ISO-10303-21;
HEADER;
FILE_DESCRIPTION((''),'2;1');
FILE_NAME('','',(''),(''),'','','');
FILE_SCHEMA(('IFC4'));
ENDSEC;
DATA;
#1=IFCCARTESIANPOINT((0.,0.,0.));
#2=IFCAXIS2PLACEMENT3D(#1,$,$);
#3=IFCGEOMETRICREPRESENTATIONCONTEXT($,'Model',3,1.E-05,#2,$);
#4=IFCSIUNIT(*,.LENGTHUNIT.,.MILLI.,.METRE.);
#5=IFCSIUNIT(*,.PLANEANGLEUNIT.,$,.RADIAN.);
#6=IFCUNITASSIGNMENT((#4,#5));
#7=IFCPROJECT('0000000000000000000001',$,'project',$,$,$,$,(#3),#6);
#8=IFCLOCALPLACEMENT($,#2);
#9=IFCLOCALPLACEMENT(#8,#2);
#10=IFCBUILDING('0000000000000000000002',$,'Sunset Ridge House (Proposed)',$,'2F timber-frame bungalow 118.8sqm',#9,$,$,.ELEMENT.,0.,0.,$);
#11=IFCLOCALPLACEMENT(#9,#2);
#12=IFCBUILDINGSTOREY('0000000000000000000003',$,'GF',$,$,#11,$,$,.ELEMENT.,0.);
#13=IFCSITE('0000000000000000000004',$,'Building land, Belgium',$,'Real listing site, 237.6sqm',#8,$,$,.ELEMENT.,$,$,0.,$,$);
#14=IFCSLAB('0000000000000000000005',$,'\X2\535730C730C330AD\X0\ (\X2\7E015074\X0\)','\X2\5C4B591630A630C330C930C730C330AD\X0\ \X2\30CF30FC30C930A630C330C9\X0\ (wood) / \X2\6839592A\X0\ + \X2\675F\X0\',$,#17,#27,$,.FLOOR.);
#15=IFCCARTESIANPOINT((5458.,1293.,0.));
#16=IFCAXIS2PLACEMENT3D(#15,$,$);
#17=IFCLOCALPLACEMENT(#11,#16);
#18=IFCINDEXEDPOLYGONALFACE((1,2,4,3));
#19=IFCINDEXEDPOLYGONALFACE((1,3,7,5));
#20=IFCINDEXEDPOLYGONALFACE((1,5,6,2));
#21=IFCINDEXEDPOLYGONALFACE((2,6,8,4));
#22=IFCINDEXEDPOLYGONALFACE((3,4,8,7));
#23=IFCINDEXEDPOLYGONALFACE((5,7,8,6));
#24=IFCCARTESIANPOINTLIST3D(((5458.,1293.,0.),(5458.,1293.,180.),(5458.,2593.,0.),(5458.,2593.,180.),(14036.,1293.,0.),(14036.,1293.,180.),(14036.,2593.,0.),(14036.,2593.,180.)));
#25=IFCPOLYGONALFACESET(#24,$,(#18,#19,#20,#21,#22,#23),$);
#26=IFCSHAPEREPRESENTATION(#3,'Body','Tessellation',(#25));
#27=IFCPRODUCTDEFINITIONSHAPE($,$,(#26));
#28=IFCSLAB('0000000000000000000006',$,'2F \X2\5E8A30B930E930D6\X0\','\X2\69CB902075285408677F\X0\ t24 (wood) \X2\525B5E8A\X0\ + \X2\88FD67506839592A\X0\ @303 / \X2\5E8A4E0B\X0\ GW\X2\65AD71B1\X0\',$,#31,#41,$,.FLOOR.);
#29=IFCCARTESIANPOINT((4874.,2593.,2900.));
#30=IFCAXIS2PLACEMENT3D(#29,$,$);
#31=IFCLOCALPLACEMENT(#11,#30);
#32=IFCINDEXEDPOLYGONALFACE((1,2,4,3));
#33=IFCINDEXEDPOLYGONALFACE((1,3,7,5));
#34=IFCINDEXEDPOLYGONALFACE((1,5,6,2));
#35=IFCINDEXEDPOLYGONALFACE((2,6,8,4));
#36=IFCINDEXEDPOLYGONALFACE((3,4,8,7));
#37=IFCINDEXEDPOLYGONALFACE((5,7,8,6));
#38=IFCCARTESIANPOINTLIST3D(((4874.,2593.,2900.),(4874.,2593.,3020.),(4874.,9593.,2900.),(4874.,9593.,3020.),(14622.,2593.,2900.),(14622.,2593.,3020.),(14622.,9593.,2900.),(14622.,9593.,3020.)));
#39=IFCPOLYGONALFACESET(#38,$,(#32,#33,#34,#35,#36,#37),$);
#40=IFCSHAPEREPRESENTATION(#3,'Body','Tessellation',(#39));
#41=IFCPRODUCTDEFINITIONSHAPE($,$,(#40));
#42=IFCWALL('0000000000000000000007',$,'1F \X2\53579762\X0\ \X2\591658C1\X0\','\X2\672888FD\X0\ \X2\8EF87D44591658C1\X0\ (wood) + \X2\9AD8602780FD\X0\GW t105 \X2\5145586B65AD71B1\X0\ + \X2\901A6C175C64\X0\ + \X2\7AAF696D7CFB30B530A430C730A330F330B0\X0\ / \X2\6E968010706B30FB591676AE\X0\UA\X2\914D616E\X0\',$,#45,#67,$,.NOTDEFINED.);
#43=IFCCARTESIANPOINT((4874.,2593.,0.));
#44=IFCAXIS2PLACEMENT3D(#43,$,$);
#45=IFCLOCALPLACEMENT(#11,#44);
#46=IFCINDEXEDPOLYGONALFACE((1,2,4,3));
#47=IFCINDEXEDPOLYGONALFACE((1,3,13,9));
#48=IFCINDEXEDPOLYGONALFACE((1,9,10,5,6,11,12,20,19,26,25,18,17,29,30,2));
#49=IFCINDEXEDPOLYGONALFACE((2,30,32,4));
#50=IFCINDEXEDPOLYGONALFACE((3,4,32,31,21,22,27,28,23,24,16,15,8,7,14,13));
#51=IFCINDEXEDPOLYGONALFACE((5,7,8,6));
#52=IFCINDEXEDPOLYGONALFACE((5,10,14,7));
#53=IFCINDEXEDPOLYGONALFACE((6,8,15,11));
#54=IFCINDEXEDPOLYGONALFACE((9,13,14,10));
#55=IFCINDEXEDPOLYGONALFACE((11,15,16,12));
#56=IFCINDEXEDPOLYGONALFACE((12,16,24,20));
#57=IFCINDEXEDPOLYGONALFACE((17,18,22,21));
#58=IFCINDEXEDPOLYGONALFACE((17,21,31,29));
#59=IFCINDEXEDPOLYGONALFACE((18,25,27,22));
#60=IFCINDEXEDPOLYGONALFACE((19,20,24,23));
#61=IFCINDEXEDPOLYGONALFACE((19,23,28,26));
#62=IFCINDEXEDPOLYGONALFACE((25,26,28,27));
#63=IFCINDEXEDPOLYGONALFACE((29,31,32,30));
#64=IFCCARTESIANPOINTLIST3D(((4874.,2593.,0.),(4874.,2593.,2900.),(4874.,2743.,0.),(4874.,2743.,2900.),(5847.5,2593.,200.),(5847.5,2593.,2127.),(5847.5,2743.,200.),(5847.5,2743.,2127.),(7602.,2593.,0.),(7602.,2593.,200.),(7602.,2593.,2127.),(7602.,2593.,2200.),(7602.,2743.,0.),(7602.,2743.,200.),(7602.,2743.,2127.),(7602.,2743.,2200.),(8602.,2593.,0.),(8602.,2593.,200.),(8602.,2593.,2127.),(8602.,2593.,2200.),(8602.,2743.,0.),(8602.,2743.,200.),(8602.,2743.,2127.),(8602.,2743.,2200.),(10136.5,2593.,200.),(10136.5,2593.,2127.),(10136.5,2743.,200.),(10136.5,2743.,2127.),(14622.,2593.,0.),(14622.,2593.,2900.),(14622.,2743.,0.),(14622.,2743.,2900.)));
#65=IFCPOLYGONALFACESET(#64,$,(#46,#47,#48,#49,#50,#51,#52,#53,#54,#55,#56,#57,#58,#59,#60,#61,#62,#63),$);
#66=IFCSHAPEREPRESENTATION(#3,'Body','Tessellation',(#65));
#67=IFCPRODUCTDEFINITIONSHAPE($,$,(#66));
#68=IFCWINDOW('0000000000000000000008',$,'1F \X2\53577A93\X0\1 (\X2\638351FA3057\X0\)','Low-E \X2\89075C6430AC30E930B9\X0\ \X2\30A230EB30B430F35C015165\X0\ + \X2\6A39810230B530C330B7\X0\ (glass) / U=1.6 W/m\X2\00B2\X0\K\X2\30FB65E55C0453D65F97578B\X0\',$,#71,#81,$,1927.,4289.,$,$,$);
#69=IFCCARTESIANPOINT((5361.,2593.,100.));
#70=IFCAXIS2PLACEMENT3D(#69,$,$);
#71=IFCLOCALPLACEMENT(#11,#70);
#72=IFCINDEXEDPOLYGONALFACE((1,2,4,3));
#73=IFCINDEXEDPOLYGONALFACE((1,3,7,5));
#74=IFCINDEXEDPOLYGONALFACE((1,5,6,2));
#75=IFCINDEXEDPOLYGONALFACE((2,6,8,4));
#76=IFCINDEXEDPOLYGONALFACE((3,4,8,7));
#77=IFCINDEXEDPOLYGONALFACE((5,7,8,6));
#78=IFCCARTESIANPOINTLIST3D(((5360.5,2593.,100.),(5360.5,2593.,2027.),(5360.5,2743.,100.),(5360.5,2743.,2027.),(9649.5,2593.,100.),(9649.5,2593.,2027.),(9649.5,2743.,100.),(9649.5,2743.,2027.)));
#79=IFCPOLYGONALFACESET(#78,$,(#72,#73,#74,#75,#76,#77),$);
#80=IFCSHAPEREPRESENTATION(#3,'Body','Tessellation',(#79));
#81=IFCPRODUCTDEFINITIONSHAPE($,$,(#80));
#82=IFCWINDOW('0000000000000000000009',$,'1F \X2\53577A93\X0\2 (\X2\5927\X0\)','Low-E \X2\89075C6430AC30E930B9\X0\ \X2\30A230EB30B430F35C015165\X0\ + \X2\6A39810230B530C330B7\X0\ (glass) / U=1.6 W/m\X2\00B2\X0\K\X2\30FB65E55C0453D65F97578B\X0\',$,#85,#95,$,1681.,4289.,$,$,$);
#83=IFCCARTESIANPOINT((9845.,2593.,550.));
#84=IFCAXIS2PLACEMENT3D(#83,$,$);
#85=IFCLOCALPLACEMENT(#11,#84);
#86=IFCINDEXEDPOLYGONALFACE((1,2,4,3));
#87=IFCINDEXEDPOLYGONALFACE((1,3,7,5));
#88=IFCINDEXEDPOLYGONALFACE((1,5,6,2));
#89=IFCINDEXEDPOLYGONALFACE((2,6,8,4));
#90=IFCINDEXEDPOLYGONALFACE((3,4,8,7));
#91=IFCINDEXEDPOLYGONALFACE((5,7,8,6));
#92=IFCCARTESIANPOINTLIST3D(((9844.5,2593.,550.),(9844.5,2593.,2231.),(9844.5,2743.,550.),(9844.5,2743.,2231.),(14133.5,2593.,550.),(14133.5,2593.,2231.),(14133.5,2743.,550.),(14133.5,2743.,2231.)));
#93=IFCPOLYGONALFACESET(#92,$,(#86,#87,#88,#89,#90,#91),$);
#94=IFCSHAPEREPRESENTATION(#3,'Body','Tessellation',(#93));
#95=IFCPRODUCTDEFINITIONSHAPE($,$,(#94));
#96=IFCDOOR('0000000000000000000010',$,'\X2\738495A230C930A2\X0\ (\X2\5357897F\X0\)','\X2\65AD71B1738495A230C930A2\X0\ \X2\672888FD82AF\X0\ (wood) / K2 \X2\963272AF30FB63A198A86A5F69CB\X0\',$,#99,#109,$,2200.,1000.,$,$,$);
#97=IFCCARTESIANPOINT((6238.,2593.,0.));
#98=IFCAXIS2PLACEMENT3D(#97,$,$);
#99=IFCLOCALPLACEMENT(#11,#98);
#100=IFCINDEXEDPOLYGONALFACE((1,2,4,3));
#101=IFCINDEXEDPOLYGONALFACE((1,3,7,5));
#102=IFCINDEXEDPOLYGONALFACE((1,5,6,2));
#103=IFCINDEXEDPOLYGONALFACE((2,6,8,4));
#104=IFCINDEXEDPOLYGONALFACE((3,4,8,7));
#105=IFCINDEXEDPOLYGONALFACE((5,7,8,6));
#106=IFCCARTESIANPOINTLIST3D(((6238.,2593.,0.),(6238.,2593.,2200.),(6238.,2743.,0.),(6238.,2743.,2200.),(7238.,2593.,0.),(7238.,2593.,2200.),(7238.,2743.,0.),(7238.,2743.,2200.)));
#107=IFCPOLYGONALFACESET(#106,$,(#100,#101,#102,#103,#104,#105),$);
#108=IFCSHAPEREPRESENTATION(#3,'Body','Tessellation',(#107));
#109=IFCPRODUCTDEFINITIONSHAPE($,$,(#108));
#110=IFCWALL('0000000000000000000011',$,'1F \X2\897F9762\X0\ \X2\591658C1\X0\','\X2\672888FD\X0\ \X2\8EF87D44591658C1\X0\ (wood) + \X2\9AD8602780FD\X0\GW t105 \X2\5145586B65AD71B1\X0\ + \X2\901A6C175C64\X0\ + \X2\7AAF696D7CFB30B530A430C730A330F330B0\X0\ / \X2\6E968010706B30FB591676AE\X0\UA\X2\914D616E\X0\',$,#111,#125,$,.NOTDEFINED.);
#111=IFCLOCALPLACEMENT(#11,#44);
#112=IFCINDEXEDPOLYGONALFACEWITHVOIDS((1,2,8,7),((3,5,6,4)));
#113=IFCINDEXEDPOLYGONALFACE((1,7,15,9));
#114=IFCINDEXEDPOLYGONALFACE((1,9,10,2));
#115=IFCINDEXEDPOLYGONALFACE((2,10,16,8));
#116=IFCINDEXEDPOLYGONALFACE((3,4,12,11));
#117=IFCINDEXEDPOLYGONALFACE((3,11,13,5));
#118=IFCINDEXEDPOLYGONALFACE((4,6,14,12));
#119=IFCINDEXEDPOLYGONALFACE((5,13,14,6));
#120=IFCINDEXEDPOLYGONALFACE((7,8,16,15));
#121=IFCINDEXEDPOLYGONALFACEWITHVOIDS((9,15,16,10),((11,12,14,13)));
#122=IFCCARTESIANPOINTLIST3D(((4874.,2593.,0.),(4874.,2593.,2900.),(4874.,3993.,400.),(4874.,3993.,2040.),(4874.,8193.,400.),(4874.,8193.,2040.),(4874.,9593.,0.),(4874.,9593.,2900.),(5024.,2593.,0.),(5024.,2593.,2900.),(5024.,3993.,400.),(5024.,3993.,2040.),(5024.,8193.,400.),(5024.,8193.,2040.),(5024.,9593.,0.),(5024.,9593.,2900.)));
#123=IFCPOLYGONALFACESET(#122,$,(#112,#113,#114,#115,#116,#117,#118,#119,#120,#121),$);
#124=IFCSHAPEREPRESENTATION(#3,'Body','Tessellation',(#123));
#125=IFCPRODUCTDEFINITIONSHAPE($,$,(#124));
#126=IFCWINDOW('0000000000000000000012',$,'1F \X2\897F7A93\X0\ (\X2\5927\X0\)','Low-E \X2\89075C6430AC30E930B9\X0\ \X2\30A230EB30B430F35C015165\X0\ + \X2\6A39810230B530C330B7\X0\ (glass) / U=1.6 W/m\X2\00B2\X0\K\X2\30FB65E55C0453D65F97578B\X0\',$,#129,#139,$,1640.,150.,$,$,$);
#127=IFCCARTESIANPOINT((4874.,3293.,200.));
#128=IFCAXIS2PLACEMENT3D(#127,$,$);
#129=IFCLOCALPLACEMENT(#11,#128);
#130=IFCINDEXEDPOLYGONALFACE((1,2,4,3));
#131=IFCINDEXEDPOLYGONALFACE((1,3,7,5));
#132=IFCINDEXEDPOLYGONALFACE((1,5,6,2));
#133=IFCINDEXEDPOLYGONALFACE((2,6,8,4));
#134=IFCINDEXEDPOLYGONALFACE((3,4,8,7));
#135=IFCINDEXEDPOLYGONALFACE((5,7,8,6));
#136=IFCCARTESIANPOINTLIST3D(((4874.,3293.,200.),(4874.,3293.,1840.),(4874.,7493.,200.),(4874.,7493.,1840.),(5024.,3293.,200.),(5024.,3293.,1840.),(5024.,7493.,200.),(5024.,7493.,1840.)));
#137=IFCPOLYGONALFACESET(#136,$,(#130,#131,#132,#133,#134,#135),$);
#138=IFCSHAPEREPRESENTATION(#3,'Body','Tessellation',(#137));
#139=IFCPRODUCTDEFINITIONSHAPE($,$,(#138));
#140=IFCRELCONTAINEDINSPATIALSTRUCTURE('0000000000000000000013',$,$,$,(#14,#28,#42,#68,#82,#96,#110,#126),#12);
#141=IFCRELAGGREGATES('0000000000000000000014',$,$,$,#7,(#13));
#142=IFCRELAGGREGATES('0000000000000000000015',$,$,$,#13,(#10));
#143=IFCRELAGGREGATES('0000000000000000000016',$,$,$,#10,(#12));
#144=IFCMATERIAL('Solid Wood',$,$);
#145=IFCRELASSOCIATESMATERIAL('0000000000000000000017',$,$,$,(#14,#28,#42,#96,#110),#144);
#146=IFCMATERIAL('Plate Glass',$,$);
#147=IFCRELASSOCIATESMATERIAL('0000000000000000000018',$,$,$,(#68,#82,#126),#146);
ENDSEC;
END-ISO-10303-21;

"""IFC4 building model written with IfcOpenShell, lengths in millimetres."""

from ifc_helpers import new_model, si_unit, frame, frame_2d, origin, place, context, project, spatial, rectangle, extrude, material, element, fill, save


model = new_model("IFC4")

# Units and contexts
model_context = context("Model", 3, precision=1e-05, world=origin())
ifc_project = project(units=[si_unit("LENGTHUNIT", "METRE", prefix="MILLI"), si_unit("PLANEANGLEUNIT", "RADIAN")], contexts=[model_context])

# Site, building, storey
site_placement = place(None, origin())
site = spatial("IfcSite", under=ifc_project, at=site_placement, Name="Building land, Belgium", ObjectType="Real listing site, 237.6sqm", CompositionType="ELEMENT", RefElevation=0.0)
building_placement = place(site_placement, origin())
building = spatial("IfcBuilding", under=site, at=building_placement, Name="Sunset Ridge House (Proposed)", ObjectType="2F timber-frame bungalow 118.8sqm", CompositionType="ELEMENT", ElevationOfRefHeight=0.0, ElevationOfTerrain=0.0)
storey_placement = place(building_placement, origin())
storey = spatial("IfcBuildingStorey", under=building, at=storey_placement, Name="GF", CompositionType="ELEMENT", Elevation=0.0)

# Slabs
ifc_material_1 = material(Name="Solid Wood")
slab_1_placement = place(storey_placement, frame((5458.0, 1293.0, 0.0)))
element("IfcSlab", 1, at=slab_1_placement, inside=storey, material=ifc_material_1, Name="南デッキ (縁側)", Description="屋外ウッドデッキ ハードウッド (wood) / 根太 + 束", PredefinedType="FLOOR", context=model_context, shape_type="SweptSolid", body=[
    extrude(rectangle(XDim=8578.0, YDim=1300.0, at=frame_2d((4289.0, 650.0))), frame((5458.0, 1293.0, 0.0)), (0.0, 0.0, 1.0), 180.0),
])
slab_2_placement = place(storey_placement, frame((4874.0, 2593.0, 2900.0)))
element("IfcSlab", 2, at=slab_2_placement, inside=storey, material=ifc_material_1, Name="2F 床スラブ", Description="構造用合板 t24 (wood) 剛床 + 製材根太 @303 / 床下 GW断熱", PredefinedType="FLOOR", context=model_context, shape_type="SweptSolid", body=[
    extrude(rectangle(XDim=9748.0, YDim=7000.0, at=frame_2d((4874.0, 3500.0))), frame((4874.0, 2593.0, 2900.0)), (0.0, 0.0, 1.0), 120.0),
])

# Wall, openings, windows, door
wall_1_placement = place(storey_placement, frame((4874.0, 2593.0, 0.0)))
wall_1 = element("IfcWall", 3, at=wall_1_placement, inside=storey, material=ifc_material_1, Name="1F 南面 外壁", Description="木製 軸組外壁 (wood) + 高性能GW t105 充填断熱 + 通気層 + 窯業系サイディング / 準耐火・外皮UA配慮", PredefinedType="NOTDEFINED", context=model_context, shape_type="SweptSolid", body=[
    extrude(rectangle(XDim=9748.0, YDim=150.0, at=frame_2d((4874.0, 75.0))), frame((4874.0, 2593.0, 0.0)), (0.0, 0.0, 1.0), 2900.0),
])
opening_1_placement = place(storey_placement, frame((5361.0, 2593.0, 100.0)))
opening_1 = element("IfcOpeningElement", 4, at=opening_1_placement, cuts=wall_1, PredefinedType="NOTDEFINED", context=model_context, shape_type="SweptSolid", body=[
    extrude(rectangle(XDim=4289.0, YDim=150.0, at=frame_2d((2144.0, 75.0))), frame((5361.0, 2593.0, 100.0)), (0.0, 0.0, 1.0), 1927.0),
])
opening_2_placement = place(storey_placement, frame((9845.0, 2593.0, 550.0)))
opening_2 = element("IfcOpeningElement", 5, at=opening_2_placement, cuts=wall_1, PredefinedType="NOTDEFINED", context=model_context, shape_type="SweptSolid", body=[
    extrude(rectangle(XDim=4289.0, YDim=150.0, at=frame_2d((2144.0, 75.0))), frame((9845.0, 2593.0, 550.0)), (0.0, 0.0, 1.0), 1681.0),
])
opening_3_placement = place(storey_placement, frame((6238.0, 2593.0, 0.0)))
opening_3 = element("IfcOpeningElement", 6, at=opening_3_placement, cuts=wall_1, PredefinedType="NOTDEFINED", context=model_context, shape_type="SweptSolid", body=[
    extrude(rectangle(XDim=1000.0, YDim=150.0, at=frame_2d((500.0, 75.0))), frame((6238.0, 2593.0, 0.0)), (0.0, 0.0, 1.0), 2200.0),
])
ifc_material_2 = material(Name="Plate Glass")
window_1_placement = place(storey_placement, frame((5361.0, 2593.0, 100.0)))
window_1 = element("IfcWindow", 7, at=window_1_placement, inside=storey, material=ifc_material_2, Name="1F 南窓1 (掃出し)", Description="Low-E 複層ガラス アルゴン封入 + 樹脂サッシ (glass) / U=1.6 W/m²K・日射取得型", OverallHeight=1927.0, OverallWidth=4289.0, context=model_context, shape_type="SweptSolid", body=[
    extrude(rectangle(XDim=4289.0, YDim=150.0, at=frame_2d((2144.0, 75.0))), frame((5361.0, 2593.0, 100.0)), (0.0, 0.0, 1.0), 1927.0),
])
fill(opening_1, window_1)
window_2_placement = place(storey_placement, frame((9845.0, 2593.0, 550.0)))
window_2 = element("IfcWindow", 8, at=window_2_placement, inside=storey, material=ifc_material_2, Name="1F 南窓2 (大)", Description="Low-E 複層ガラス アルゴン封入 + 樹脂サッシ (glass) / U=1.6 W/m²K・日射取得型", OverallHeight=1681.0, OverallWidth=4289.0, context=model_context, shape_type="SweptSolid", body=[
    extrude(rectangle(XDim=4289.0, YDim=150.0, at=frame_2d((2144.0, 75.0))), frame((9845.0, 2593.0, 550.0)), (0.0, 0.0, 1.0), 1681.0),
])
fill(opening_2, window_2)
door_placement = place(storey_placement, frame((6238.0, 2593.0, 0.0)))
door = element("IfcDoor", 9, at=door_placement, inside=storey, material=ifc_material_1, Name="玄関ドア (南西)", Description="断熱玄関ドア 木製芯 (wood) / K2 防犯・採風機構", OverallHeight=2200.0, OverallWidth=1000.0, context=model_context, shape_type="SweptSolid", body=[
    extrude(rectangle(XDim=1000.0, YDim=150.0, at=frame_2d((500.0, 75.0))), frame((6238.0, 2593.0, 0.0)), (0.0, 0.0, 1.0), 2200.0),
])
fill(opening_3, door)

# Wall, opening, window
wall_2_placement = place(storey_placement, frame((4874.0, 2593.0, 0.0)))
wall_2 = element("IfcWall", 10, at=wall_2_placement, inside=storey, material=ifc_material_1, Name="1F 西面 外壁", Description="木製 軸組外壁 (wood) + 高性能GW t105 充填断熱 + 通気層 + 窯業系サイディング / 準耐火・外皮UA配慮", PredefinedType="NOTDEFINED", context=model_context, shape_type="SweptSolid", body=[
    extrude(rectangle(XDim=150.0, YDim=7000.0, at=frame_2d((75.0, 3500.0))), frame((4874.0, 2593.0, 0.0)), (0.0, 0.0, 1.0), 2900.0),
])
opening_4_placement = place(storey_placement, frame((4874.0, 3293.0, 200.0)))
opening_4 = element("IfcOpeningElement", 11, at=opening_4_placement, cuts=wall_2, PredefinedType="NOTDEFINED", context=model_context, shape_type="SweptSolid", body=[
    extrude(rectangle(XDim=150.0, YDim=4200.0, at=frame_2d((75.0, 2100.0))), frame((4874.0, 3293.0, 200.0)), (0.0, 0.0, 1.0), 1640.0),
])
window_3_placement = place(storey_placement, frame((4874.0, 3293.0, 200.0)))
window_3 = element("IfcWindow", 12, at=window_3_placement, inside=storey, material=ifc_material_2, Name="1F 西窓 (大)", Description="Low-E 複層ガラス アルゴン封入 + 樹脂サッシ (glass) / U=1.6 W/m²K・日射取得型", OverallHeight=1640.0, OverallWidth=150.0, context=model_context, shape_type="SweptSolid", body=[
    extrude(rectangle(XDim=150.0, YDim=4200.0, at=frame_2d((75.0, 2100.0))), frame((4874.0, 3293.0, 200.0)), (0.0, 0.0, 1.0), 1640.0),
])
fill(opening_4, window_3)

save(model, "model.ifc")
